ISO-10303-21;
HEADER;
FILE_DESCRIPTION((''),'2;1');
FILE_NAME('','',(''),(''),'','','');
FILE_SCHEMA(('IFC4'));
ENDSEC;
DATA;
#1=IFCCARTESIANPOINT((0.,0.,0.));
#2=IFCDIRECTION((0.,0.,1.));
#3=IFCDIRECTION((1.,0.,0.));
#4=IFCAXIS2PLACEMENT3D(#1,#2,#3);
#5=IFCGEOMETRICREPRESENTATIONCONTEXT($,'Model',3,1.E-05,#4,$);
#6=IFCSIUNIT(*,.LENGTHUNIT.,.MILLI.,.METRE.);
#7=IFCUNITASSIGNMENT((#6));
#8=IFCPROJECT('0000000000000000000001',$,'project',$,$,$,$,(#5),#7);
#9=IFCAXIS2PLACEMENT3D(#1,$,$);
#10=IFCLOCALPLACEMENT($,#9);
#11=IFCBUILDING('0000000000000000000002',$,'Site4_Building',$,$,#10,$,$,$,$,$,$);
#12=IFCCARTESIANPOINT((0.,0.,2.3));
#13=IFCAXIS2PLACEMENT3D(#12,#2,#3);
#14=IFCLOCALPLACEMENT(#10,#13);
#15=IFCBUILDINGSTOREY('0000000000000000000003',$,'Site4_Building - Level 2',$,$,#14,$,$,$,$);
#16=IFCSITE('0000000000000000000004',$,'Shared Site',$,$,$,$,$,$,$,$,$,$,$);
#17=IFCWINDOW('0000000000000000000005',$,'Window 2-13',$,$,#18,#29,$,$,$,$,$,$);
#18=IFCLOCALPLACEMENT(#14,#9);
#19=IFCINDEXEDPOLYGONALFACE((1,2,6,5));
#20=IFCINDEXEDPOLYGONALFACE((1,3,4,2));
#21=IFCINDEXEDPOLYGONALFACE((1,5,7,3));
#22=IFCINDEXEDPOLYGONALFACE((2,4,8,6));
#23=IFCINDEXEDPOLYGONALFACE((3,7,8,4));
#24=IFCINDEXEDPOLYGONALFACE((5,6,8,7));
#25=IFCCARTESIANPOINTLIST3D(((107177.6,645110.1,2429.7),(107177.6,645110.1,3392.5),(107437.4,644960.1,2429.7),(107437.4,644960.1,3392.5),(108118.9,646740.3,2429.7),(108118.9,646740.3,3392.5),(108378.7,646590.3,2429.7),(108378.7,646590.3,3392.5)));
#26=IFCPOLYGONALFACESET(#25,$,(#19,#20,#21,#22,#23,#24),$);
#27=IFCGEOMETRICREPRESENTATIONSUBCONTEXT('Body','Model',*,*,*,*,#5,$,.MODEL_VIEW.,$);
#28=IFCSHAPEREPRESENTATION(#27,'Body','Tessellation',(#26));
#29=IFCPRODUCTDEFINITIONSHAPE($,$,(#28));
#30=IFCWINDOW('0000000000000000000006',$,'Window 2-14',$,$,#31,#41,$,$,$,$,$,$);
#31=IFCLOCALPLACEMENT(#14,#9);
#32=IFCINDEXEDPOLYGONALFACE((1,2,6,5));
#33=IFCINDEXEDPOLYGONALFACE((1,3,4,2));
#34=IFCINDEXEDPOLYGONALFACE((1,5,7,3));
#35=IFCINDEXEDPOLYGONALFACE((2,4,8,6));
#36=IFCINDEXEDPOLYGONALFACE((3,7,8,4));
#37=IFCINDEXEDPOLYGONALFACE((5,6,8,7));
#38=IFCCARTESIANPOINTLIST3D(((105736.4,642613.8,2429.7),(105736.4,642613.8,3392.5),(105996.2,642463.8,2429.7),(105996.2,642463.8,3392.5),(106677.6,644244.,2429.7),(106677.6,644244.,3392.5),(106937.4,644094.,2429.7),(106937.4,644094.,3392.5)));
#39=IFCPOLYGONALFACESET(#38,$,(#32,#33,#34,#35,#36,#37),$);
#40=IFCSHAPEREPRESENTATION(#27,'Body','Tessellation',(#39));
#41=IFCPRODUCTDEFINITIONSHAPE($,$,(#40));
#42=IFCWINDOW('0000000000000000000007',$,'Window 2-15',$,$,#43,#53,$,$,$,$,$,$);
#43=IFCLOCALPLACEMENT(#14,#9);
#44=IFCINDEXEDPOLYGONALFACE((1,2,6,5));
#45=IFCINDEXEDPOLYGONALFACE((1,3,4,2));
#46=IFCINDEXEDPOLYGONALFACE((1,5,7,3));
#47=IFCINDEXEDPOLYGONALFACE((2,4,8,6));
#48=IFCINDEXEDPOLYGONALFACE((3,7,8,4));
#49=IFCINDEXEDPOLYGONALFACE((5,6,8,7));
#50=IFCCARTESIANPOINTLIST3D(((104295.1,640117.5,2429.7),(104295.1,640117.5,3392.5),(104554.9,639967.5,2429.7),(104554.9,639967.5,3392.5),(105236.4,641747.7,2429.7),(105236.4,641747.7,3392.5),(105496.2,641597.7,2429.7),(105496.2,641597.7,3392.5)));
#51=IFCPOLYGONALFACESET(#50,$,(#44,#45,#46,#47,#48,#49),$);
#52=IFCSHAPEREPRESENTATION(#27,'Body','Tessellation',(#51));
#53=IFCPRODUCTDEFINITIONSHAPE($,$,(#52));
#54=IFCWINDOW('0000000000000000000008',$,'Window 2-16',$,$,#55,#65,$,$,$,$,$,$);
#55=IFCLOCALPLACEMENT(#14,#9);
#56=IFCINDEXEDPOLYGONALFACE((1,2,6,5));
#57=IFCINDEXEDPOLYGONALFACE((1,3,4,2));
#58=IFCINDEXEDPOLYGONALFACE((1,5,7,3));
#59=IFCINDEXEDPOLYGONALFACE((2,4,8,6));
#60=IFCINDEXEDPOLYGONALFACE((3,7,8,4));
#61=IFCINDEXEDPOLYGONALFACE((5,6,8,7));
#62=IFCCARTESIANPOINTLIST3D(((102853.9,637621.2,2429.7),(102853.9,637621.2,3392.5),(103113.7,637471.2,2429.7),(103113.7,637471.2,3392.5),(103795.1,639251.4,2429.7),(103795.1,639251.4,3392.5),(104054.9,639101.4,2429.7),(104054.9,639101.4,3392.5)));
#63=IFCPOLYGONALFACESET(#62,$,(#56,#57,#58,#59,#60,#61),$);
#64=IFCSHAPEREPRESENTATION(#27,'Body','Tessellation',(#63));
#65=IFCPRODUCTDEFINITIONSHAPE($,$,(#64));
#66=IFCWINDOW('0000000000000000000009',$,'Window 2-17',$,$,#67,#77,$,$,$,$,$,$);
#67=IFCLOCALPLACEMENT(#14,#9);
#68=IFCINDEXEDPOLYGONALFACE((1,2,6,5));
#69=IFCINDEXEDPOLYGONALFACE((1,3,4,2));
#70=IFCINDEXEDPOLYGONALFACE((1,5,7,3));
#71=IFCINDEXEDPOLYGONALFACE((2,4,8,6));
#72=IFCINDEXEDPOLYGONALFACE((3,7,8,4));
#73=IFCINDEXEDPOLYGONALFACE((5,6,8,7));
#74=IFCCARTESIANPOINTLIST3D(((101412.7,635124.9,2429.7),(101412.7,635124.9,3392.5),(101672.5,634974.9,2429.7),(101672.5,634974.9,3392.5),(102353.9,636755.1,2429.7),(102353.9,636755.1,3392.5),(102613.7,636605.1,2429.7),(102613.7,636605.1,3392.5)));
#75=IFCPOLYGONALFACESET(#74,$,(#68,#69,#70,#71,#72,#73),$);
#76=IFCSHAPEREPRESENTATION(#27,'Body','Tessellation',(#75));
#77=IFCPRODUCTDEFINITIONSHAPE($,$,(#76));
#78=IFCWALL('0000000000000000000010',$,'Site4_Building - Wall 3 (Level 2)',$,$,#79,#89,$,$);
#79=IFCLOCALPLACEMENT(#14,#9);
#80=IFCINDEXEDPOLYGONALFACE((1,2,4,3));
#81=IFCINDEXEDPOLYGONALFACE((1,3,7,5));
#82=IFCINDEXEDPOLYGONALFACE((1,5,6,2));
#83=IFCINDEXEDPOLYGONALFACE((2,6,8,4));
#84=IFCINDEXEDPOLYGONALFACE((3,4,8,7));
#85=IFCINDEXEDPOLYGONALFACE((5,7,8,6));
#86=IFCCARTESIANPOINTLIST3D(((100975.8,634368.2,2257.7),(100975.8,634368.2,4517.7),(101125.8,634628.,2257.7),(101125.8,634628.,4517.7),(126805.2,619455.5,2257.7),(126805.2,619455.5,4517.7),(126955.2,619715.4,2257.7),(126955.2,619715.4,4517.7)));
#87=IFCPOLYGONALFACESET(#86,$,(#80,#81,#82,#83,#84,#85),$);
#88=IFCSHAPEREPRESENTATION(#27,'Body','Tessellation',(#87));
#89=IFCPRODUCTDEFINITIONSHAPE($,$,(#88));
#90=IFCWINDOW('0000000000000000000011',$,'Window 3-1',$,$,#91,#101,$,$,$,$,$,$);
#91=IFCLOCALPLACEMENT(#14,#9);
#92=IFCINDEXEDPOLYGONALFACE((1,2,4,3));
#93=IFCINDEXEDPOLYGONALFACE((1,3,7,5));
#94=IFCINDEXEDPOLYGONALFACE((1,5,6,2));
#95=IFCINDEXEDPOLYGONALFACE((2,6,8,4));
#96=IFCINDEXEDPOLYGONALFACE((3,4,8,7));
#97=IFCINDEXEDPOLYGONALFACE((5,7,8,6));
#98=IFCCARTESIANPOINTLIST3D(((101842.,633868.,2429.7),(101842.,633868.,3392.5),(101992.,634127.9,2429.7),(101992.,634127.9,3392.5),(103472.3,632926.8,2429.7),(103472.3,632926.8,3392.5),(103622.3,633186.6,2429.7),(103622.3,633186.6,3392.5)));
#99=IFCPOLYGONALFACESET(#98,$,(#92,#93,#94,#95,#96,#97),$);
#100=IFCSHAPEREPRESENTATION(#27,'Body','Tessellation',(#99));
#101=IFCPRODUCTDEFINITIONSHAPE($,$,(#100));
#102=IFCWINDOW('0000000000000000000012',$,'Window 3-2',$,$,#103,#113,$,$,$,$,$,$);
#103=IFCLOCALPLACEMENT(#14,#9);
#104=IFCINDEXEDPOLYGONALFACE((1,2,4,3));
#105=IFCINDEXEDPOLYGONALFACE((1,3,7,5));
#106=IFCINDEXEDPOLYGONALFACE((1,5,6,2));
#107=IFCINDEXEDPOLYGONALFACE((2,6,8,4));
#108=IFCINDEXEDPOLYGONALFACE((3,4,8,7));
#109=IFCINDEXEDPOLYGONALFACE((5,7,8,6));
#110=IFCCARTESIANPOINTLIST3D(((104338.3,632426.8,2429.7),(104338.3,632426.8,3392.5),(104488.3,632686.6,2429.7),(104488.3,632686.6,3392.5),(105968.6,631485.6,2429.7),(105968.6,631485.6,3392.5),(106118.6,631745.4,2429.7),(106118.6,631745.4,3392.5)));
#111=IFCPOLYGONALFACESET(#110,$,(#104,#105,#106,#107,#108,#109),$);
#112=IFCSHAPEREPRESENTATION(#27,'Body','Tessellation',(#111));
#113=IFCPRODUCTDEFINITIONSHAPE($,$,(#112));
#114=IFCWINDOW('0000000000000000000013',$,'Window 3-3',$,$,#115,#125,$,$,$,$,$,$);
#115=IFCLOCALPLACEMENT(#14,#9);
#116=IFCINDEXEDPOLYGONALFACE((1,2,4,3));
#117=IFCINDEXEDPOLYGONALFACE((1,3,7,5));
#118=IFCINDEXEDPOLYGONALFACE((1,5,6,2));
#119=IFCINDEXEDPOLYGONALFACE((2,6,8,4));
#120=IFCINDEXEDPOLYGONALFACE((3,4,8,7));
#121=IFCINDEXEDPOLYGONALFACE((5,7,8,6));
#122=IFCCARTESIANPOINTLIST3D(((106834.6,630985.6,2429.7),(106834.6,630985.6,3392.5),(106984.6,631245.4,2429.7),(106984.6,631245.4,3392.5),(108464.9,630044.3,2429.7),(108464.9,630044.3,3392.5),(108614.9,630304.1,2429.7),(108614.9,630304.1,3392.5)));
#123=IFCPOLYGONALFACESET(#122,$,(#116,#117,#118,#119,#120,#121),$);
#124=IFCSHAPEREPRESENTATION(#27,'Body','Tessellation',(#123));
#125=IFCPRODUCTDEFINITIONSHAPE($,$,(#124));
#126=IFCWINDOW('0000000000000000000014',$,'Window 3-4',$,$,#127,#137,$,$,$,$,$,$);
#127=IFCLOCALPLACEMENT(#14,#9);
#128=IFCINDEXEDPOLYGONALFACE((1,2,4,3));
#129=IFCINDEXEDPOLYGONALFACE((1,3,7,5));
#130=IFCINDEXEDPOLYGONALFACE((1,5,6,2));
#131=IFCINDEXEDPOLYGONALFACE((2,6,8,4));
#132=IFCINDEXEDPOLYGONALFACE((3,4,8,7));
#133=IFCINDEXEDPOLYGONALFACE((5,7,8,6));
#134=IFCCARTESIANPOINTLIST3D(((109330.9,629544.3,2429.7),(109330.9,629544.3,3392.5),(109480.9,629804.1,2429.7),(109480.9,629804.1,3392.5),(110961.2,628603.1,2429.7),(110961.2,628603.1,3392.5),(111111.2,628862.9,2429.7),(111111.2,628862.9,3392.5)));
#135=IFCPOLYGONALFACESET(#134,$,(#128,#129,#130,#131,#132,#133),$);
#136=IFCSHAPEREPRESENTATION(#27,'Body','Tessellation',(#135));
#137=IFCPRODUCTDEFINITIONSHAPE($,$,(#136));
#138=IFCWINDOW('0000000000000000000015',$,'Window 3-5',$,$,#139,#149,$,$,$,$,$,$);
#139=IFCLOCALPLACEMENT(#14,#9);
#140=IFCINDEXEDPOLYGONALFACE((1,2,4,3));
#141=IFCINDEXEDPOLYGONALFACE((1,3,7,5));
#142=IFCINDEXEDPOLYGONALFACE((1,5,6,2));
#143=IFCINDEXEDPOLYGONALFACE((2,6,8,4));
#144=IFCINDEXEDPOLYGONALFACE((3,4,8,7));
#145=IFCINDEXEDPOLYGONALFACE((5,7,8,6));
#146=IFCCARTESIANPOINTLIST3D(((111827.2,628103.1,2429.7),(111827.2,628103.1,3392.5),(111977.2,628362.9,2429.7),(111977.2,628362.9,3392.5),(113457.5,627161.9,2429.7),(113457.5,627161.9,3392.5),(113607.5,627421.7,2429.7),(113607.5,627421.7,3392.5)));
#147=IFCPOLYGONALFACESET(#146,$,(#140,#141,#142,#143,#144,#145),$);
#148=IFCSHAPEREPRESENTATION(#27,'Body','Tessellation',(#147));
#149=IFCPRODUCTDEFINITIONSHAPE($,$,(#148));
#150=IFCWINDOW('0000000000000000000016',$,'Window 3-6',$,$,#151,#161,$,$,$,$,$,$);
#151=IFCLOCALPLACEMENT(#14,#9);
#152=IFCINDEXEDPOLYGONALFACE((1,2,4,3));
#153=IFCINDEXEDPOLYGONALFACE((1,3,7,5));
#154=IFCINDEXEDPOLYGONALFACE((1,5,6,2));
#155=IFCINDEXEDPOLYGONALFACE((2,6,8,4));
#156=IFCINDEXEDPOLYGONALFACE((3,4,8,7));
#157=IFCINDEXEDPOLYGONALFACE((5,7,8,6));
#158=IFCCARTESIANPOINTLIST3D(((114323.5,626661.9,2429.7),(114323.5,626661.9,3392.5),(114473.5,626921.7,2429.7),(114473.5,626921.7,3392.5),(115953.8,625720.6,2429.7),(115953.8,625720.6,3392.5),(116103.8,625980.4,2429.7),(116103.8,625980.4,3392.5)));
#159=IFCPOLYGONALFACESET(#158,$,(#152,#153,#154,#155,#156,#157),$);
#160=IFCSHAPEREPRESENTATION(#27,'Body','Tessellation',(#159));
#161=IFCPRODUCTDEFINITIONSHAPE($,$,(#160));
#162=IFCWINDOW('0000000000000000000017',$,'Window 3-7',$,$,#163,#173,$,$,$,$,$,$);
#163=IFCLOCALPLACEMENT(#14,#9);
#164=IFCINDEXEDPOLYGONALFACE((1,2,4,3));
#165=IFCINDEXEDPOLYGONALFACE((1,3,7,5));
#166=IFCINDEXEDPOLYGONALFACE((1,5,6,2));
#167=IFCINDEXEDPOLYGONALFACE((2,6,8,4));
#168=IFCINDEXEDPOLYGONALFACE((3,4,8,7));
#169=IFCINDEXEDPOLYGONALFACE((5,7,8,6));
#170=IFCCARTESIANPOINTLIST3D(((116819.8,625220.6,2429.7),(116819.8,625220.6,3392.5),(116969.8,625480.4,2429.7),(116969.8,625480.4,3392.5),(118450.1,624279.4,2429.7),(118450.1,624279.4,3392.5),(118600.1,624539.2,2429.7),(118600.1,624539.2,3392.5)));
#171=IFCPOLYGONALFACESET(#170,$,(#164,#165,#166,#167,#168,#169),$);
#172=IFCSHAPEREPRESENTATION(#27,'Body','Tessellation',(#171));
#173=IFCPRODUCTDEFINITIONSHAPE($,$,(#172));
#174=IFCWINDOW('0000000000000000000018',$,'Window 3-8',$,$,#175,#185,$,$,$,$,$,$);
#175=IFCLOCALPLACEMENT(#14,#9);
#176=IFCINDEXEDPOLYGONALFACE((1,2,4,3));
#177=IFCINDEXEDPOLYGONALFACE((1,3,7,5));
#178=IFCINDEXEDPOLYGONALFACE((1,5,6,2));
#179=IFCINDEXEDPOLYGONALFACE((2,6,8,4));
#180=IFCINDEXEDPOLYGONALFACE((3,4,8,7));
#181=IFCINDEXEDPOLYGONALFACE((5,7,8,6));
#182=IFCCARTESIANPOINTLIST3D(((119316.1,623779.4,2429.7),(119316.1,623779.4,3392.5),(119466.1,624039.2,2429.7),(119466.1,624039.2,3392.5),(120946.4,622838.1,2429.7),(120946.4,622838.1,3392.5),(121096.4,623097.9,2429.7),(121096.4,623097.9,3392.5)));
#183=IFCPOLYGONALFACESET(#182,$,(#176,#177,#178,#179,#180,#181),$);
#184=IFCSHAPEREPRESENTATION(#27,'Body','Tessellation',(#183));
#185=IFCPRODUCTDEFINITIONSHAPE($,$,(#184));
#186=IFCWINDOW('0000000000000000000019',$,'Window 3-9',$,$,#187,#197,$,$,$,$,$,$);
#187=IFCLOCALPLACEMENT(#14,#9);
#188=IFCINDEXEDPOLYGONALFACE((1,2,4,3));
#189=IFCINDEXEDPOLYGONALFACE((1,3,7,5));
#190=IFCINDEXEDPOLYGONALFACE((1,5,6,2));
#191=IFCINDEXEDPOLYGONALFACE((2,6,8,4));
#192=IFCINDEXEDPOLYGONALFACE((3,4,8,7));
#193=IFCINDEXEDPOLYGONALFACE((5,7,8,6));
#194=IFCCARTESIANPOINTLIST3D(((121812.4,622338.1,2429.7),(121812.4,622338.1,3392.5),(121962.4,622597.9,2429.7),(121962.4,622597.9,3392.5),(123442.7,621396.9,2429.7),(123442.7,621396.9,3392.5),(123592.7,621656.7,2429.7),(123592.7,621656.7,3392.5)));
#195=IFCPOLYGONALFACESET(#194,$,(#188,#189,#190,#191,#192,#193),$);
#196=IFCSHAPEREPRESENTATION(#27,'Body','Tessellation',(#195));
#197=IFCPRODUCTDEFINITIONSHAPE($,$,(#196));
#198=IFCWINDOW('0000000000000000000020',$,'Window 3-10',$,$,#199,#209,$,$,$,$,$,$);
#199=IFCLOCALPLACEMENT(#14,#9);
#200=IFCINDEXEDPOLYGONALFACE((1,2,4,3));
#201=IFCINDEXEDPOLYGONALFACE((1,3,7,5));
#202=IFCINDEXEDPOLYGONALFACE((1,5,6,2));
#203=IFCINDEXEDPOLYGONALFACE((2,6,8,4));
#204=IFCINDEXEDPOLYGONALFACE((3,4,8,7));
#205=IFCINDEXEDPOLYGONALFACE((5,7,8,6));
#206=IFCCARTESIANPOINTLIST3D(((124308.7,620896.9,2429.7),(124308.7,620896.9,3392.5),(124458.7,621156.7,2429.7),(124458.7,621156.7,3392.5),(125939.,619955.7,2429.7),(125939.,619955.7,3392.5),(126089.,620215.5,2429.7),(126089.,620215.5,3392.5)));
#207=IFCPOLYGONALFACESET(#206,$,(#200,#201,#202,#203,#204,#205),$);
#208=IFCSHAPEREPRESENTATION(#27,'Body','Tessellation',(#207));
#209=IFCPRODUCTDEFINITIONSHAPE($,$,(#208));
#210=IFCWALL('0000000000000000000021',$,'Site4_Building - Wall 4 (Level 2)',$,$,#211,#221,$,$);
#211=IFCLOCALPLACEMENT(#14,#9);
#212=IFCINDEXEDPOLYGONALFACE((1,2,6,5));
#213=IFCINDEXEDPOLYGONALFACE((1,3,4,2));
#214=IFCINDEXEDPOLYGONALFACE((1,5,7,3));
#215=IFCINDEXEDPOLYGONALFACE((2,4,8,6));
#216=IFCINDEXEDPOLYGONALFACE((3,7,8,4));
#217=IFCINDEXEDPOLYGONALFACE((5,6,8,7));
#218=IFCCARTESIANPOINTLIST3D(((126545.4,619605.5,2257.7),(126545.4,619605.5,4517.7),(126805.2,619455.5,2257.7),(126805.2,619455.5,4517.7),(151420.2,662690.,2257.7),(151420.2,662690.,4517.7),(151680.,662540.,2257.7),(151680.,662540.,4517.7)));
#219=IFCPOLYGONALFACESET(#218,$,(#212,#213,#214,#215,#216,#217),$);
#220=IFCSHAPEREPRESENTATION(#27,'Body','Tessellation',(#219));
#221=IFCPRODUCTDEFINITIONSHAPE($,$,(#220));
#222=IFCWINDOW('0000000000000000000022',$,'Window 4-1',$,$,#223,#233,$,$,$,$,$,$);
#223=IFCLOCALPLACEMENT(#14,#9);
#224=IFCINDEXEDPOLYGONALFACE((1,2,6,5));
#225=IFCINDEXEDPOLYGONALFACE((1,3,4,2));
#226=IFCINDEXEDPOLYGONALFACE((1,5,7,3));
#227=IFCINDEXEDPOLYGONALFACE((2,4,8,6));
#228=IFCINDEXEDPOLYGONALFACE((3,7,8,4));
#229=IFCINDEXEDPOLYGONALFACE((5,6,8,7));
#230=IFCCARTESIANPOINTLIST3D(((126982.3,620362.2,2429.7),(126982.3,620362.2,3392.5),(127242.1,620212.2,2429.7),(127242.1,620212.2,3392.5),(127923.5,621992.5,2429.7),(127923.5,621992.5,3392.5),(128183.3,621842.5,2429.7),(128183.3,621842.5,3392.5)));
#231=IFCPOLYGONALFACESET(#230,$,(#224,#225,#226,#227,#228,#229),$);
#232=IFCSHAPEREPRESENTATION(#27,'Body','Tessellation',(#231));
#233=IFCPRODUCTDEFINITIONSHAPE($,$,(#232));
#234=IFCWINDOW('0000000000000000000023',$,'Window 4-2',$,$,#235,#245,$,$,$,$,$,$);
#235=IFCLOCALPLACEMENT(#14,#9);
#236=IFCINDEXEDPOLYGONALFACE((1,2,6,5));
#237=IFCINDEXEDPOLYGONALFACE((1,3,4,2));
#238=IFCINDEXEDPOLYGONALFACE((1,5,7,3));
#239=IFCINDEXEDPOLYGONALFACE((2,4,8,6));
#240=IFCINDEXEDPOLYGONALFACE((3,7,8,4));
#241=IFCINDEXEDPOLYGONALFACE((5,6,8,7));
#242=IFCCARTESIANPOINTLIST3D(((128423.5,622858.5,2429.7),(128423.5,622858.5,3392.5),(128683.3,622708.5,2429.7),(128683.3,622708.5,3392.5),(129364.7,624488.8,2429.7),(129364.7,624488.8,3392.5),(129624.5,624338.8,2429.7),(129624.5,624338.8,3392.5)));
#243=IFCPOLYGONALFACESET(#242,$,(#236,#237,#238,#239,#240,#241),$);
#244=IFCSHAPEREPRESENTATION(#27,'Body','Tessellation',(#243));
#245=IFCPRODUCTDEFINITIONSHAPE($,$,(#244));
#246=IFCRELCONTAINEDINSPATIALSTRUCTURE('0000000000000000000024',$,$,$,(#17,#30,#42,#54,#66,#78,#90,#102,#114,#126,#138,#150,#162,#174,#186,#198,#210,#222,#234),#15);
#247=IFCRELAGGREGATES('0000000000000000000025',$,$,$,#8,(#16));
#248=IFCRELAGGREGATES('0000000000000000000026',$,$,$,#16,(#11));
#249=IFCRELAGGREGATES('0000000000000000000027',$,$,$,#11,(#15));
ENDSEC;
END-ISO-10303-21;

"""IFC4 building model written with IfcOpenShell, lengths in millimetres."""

from ifc_helpers import new_model, si_unit, frame, origin, origin_with_axes, place, context, subcontext, project, spatial, indexed_curve, outline, extrude, element, save


model = new_model("IFC4")

# Units and contexts
model_context = context("Model", 3, precision=1e-05, world=origin_with_axes())
body_context = subcontext(model_context, "Body", "Model", "MODEL_VIEW")
ifc_project = project(units=[si_unit("LENGTHUNIT", "METRE", prefix="MILLI")], contexts=[model_context])

# Site, building, storey
site = spatial("IfcSite", under=ifc_project, Name="Shared Site")
building_placement = place(None, origin())
building = spatial("IfcBuilding", under=site, at=building_placement, Name="Site4_Building")
storey_placement = place(building_placement, frame((0.0, 0.0, 2.3), z_axis=(0.0, 0.0, 1.0), x_axis=(1.0, 0.0, 0.0)))
storey = spatial("IfcBuildingStorey", under=building, at=storey_placement, Name="Site4_Building - Level 2")

# Windows
for number, where, z_axis, x_axis, name in (
    (1, (108118.9, 646740.3, 2429.7), (0.0, 0.0, 1.0), (-0.5, -0.866025, 0.0), "Window 2-13"),
    (2, (106677.6, 644244.0, 2429.7), (0.0, 0.0, 1.0), (-0.5, -0.866025, 0.0), "Window 2-14"),
    (3, (105236.4, 641747.7, 2429.7), (0.0, 0.0, 1.0), (-0.5, -0.866025, 0.0), "Window 2-15"),
    (4, (103795.1, 639251.4, 2429.7), (0.0, 0.0, 1.0), (-0.5, -0.866025, 0.0), "Window 2-16"),
    (5, (102353.9, 636755.1, 2429.7), (0.0, 0.0, 1.0), (-0.5, -0.866025, 0.0), "Window 2-17"),
):
    element("IfcWindow", number, at=place(storey_placement, frame(where, z_axis=z_axis, x_axis=x_axis)), inside=storey, Name=name, context=body_context, shape_type="SweptSolid", body=[
        extrude(outline(indexed_curve([(0.0, 0.0), (0.0, 300.0), (1882.5, 300.0), (1882.5, 0.0), (0.0, 0.0)], self_intersect=False)), origin_with_axes(), (0.0, 0.0, 1.0), 962.8),
    ])

# Wall
wall_1_placement = place(storey_placement, frame((100975.8, 634368.2, 2257.7), z_axis=(0.0, 0.0, 1.0), x_axis=(0.866025, -0.5, 0.0)))
element("IfcWall", 6, at=wall_1_placement, inside=storey, Name="Site4_Building - Wall 3 (Level 2)", context=body_context, shape_type="SweptSolid", body=[
    extrude(outline(indexed_curve([(0.0, 0.0), (0.0, 300.0), (29825.2, 300.0), (29825.2, 0.0), (0.0, 0.0)], self_intersect=False)), origin_with_axes(), (0.0, 0.0, 1.0), 2260.0),
])

# Windows
for number, where, z_axis, x_axis, name in (
    (7, (101842.0, 633868.0, 2429.7), (0.0, 0.0, 1.0), (0.866025, -0.5, 0.0), "Window 3-1"),
    (8, (104338.3, 632426.8, 2429.7), (0.0, 0.0, 1.0), (0.866025, -0.5, 0.0), "Window 3-2"),
    (9, (106834.6, 630985.6, 2429.7), (0.0, 0.0, 1.0), (0.866025, -0.5, 0.0), "Window 3-3"),
    (10, (109330.9, 629544.3, 2429.7), (0.0, 0.0, 1.0), (0.866025, -0.5, 0.0), "Window 3-4"),
    (11, (111827.2, 628103.1, 2429.7), (0.0, 0.0, 1.0), (0.866025, -0.5, 0.0), "Window 3-5"),
    (12, (114323.5, 626661.9, 2429.7), (0.0, 0.0, 1.0), (0.866025, -0.5, 0.0), "Window 3-6"),
    (13, (116819.8, 625220.6, 2429.7), (0.0, 0.0, 1.0), (0.866025, -0.5, 0.0), "Window 3-7"),
    (14, (119316.1, 623779.4, 2429.7), (0.0, 0.0, 1.0), (0.866025, -0.5, 0.0), "Window 3-8"),
    (15, (121812.4, 622338.1, 2429.7), (0.0, 0.0, 1.0), (0.866025, -0.5, 0.0), "Window 3-9"),
    (16, (124308.7, 620896.9, 2429.7), (0.0, 0.0, 1.0), (0.866025, -0.5, 0.0), "Window 3-10"),
):
    element("IfcWindow", number, at=place(storey_placement, frame(where, z_axis=z_axis, x_axis=x_axis)), inside=storey, Name=name, context=body_context, shape_type="SweptSolid", body=[
        extrude(outline(indexed_curve([(0.0, 0.0), (0.0, 300.0), (1882.5, 300.0), (1882.5, 0.0), (0.0, 0.0)], self_intersect=False)), origin_with_axes(), (0.0, 0.0, 1.0), 962.8),
    ])

# Wall
wall_2_placement = place(storey_placement, frame((126805.2, 619455.5, 2257.7), z_axis=(0.0, 0.0, 1.0), x_axis=(0.5, 0.866025, 0.0)))
element("IfcWall", 17, at=wall_2_placement, inside=storey, Name="Site4_Building - Wall 4 (Level 2)", context=body_context, shape_type="SweptSolid", body=[
    extrude(outline(indexed_curve([(0.0, 0.0), (0.0, 300.0), (49749.6, 300.0), (49749.6, 0.0), (0.0, 0.0)], self_intersect=False)), origin_with_axes(), (0.0, 0.0, 1.0), 2260.0),
])

# Windows
for number, where, z_axis, x_axis, name in (
    (18, (127242.1, 620212.2, 2429.7), (0.0, 0.0, 1.0), (0.5, 0.866025, 0.0), "Window 4-1"),
    (19, (128683.3, 622708.5, 2429.7), (0.0, 0.0, 1.0), (0.5, 0.866025, 0.0), "Window 4-2"),
):
    element("IfcWindow", number, at=place(storey_placement, frame(where, z_axis=z_axis, x_axis=x_axis)), inside=storey, Name=name, context=body_context, shape_type="SweptSolid", body=[
        extrude(outline(indexed_curve([(0.0, 0.0), (0.0, 300.0), (1882.5, 300.0), (1882.5, 0.0), (0.0, 0.0)], self_intersect=False)), origin_with_axes(), (0.0, 0.0, 1.0), 962.8),
    ])

save(model, "model.ifc")
